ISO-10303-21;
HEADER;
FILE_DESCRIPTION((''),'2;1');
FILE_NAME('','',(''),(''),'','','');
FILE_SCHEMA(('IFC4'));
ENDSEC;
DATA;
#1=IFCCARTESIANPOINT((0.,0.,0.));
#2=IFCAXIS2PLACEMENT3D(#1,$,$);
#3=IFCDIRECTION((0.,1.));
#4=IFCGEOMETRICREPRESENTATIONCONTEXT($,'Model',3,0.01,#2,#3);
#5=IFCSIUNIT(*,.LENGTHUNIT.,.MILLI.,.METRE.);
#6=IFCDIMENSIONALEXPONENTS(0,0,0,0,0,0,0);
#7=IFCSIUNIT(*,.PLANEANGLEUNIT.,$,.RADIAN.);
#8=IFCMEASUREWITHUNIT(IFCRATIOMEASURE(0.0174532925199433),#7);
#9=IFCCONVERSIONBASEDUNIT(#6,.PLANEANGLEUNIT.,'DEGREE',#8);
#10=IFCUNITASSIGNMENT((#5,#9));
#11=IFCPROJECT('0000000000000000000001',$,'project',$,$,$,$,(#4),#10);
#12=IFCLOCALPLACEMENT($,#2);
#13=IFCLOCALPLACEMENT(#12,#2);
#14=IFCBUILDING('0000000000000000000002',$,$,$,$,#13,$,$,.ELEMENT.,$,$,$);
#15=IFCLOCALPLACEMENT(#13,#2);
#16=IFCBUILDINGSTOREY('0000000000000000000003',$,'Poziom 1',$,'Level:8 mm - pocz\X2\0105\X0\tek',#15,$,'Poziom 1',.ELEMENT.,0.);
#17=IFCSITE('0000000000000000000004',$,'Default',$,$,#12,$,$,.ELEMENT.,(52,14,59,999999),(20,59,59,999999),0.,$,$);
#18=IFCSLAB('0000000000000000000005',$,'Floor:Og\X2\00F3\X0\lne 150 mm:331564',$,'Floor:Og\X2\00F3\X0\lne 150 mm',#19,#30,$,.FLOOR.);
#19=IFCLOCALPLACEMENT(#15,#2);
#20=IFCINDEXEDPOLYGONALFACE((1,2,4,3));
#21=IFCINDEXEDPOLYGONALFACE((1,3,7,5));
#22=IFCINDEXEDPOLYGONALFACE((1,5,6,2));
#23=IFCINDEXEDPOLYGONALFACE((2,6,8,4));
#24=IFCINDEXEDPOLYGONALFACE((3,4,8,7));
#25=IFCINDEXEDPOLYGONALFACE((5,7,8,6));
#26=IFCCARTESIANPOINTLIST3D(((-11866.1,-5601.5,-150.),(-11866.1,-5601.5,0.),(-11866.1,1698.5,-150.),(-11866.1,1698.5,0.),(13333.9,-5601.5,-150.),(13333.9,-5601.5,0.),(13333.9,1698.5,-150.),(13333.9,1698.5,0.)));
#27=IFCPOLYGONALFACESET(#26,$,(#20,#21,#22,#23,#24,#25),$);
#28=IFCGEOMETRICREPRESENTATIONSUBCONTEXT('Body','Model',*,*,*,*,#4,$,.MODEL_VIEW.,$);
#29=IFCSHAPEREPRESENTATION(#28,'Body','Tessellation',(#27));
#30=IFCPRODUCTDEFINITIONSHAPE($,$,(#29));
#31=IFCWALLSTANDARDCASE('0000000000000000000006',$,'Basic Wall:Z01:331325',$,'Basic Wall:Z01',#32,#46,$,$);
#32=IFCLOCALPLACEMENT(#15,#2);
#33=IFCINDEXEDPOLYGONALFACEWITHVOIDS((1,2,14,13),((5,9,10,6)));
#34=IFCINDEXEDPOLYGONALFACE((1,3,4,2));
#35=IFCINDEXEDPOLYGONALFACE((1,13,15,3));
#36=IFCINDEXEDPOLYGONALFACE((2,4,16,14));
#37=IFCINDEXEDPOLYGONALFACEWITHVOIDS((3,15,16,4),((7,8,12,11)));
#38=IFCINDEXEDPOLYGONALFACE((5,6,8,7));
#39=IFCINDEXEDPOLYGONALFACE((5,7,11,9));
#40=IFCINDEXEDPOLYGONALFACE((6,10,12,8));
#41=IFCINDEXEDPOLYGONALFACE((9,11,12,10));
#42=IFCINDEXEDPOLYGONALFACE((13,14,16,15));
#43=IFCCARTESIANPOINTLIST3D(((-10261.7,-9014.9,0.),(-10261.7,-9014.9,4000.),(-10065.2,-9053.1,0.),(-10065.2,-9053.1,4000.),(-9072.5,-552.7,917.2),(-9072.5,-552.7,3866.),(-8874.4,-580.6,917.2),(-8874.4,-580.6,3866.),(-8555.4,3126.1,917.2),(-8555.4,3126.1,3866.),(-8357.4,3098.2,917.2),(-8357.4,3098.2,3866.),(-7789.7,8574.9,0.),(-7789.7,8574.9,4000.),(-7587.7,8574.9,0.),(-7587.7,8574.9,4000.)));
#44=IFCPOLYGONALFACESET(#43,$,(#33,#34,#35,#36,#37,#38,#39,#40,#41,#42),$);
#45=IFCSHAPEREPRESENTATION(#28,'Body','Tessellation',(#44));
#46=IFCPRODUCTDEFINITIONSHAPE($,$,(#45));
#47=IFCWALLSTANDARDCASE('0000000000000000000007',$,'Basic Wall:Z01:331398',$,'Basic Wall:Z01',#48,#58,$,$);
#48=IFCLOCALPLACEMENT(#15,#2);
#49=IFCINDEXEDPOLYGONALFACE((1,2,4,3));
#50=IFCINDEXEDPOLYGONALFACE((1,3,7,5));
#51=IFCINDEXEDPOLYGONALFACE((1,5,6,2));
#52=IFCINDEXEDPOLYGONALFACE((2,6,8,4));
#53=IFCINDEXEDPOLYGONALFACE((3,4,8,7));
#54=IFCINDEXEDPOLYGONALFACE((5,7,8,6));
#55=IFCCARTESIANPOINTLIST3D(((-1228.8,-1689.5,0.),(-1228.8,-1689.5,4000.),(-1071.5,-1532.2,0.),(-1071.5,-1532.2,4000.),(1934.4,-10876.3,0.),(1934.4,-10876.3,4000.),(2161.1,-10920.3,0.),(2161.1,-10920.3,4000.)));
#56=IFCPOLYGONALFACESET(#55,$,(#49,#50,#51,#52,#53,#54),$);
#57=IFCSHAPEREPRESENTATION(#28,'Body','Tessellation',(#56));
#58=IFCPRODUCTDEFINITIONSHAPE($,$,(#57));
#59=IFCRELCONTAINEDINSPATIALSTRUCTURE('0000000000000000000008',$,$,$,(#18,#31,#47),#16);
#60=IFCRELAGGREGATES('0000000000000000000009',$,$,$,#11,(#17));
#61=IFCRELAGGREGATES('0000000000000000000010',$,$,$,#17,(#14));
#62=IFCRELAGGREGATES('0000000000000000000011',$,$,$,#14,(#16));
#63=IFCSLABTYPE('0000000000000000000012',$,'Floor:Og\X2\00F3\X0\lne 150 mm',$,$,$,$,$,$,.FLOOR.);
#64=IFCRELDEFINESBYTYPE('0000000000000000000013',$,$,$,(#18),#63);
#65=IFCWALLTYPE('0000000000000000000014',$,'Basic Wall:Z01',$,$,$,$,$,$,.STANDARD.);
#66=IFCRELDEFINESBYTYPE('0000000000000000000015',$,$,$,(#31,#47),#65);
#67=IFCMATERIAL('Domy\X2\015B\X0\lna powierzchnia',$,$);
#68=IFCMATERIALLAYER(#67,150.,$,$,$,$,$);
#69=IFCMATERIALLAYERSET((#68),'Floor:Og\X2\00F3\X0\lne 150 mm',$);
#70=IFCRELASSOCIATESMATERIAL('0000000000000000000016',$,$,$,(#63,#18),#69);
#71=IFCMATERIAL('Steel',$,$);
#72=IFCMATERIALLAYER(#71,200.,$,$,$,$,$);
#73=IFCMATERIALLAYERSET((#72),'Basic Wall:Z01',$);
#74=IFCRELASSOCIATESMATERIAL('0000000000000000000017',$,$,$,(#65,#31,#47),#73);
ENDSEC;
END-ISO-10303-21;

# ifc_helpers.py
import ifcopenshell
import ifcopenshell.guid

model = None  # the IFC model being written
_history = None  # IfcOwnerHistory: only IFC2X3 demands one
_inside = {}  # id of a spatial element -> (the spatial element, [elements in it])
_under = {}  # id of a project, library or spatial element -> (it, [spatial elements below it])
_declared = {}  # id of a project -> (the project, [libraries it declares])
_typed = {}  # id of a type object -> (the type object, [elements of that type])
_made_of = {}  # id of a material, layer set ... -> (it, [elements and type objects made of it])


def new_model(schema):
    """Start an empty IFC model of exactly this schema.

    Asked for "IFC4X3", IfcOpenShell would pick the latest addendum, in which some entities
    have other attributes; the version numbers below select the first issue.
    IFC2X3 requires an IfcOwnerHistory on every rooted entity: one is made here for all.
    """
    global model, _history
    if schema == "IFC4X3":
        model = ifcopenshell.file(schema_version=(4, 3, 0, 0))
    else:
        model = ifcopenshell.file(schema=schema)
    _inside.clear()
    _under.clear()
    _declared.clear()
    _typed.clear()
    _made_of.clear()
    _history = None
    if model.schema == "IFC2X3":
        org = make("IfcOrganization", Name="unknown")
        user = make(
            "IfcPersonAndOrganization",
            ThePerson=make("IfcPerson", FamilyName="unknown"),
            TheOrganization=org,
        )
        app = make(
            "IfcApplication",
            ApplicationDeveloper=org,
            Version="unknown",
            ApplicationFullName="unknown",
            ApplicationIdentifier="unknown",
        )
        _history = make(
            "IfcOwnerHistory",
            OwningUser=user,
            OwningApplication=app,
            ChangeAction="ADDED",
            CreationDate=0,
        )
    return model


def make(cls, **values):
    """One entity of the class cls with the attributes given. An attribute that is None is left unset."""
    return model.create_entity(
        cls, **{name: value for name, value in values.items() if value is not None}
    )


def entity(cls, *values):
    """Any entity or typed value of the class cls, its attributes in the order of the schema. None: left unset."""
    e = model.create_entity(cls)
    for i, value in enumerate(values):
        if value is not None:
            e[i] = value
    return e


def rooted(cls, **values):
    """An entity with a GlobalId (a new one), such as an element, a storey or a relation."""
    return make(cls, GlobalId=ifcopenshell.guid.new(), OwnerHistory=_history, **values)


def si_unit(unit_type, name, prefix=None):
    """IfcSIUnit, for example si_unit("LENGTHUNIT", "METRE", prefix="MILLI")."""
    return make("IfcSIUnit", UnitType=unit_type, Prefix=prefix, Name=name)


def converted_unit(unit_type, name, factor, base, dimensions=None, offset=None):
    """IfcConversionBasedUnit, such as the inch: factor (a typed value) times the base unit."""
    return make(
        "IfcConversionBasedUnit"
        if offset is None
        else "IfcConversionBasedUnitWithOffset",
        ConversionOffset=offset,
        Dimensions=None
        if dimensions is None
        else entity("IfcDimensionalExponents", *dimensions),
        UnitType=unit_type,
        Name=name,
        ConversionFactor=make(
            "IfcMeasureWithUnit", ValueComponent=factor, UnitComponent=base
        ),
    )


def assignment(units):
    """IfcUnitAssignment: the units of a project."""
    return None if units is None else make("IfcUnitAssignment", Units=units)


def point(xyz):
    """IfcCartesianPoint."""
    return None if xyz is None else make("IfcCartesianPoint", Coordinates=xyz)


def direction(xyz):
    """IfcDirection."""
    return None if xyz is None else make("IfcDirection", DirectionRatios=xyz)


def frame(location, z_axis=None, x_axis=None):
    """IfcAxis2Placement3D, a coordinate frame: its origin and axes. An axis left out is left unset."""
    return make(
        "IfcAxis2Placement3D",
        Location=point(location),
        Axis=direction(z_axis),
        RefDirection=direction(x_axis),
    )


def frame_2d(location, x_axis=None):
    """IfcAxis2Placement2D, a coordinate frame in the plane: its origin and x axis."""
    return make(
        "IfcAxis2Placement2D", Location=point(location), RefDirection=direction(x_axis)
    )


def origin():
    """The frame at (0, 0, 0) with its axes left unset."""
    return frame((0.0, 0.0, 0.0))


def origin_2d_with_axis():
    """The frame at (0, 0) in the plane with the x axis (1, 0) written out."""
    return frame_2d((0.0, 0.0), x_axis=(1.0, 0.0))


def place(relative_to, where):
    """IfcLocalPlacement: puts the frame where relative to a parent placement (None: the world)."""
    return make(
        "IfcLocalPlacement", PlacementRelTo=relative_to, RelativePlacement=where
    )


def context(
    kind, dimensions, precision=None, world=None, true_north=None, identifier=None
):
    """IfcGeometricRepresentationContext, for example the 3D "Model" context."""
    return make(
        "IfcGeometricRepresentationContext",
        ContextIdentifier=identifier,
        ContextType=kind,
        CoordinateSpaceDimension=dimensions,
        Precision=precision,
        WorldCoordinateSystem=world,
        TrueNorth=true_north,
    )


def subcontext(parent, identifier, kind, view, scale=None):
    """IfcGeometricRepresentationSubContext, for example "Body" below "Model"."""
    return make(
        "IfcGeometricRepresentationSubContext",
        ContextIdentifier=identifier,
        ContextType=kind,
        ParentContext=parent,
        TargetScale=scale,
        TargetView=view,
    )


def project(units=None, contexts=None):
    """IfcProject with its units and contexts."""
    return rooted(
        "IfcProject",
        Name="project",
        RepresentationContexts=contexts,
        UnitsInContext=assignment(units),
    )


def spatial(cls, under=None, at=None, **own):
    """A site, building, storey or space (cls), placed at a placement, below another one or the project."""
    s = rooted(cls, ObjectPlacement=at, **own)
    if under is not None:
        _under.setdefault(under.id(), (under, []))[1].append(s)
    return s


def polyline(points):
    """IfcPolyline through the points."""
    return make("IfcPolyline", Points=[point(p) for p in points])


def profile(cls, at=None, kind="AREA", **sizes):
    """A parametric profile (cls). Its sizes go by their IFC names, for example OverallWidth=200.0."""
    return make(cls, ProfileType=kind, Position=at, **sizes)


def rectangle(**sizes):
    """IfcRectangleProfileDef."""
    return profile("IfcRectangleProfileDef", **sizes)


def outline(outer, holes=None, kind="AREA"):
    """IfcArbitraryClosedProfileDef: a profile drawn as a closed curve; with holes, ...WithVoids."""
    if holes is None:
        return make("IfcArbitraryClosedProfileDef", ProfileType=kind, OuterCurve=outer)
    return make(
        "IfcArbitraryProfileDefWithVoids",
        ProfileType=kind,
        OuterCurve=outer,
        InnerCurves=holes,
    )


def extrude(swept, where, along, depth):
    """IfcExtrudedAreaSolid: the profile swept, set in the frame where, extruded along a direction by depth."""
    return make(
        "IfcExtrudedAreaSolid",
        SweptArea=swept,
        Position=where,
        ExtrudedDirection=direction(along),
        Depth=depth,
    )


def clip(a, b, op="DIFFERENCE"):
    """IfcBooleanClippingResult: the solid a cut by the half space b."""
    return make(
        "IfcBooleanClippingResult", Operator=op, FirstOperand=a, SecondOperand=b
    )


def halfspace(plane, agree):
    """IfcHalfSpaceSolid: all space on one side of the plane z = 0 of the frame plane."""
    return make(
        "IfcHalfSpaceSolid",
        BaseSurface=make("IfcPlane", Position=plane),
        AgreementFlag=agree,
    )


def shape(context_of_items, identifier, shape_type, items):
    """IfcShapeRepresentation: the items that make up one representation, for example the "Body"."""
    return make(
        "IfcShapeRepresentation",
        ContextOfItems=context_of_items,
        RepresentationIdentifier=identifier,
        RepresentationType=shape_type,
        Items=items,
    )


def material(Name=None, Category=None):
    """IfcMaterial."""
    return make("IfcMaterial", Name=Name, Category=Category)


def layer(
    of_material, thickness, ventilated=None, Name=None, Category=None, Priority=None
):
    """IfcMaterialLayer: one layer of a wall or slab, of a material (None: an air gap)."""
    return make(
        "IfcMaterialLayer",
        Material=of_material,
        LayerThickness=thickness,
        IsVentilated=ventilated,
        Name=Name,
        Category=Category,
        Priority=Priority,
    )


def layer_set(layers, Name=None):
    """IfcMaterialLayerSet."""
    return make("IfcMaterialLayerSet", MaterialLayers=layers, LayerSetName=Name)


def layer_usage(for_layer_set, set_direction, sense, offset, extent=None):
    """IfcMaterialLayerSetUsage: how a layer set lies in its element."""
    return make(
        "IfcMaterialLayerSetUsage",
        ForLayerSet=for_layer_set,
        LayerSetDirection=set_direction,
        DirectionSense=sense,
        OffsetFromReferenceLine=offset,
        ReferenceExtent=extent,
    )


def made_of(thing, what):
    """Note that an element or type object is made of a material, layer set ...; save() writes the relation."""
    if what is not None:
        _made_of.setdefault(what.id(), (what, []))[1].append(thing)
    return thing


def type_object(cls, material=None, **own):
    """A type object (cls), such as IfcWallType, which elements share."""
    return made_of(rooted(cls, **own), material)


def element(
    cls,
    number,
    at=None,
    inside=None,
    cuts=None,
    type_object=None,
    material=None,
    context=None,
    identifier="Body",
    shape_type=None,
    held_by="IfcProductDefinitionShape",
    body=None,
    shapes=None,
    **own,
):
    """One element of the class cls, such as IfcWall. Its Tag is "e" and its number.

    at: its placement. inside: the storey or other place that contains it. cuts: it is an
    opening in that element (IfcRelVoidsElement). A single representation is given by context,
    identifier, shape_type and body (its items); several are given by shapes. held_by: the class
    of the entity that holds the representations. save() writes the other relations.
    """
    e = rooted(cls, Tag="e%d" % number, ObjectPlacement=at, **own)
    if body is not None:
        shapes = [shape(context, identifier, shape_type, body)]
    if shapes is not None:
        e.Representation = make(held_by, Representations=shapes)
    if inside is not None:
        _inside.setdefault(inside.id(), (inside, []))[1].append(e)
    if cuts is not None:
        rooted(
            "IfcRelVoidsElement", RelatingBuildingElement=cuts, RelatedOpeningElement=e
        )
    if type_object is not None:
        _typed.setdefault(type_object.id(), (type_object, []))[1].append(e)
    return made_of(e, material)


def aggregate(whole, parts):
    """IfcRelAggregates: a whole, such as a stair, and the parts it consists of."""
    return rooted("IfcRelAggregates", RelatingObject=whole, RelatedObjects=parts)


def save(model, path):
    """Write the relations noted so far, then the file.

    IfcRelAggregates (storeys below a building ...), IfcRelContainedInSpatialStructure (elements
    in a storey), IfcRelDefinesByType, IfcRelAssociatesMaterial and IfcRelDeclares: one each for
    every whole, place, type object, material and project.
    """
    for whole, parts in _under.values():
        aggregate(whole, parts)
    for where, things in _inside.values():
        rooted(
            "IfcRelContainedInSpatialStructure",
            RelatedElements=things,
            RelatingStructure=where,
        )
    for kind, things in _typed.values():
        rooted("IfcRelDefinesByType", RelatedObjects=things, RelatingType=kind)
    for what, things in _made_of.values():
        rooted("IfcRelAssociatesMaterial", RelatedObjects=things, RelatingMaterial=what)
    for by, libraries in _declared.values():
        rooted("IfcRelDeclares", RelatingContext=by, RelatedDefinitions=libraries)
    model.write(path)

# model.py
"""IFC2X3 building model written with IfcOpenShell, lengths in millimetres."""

from ifc_helpers import new_model, entity, si_unit, converted_unit, direction, frame, frame_2d, origin, origin_2d_with_axis, place, context, subcontext, project, spatial, polyline, rectangle, outline, extrude, clip, halfspace, material, layer, layer_set, layer_usage, type_object, element, save


model = new_model("IFC2X3")

# Units and contexts
model_context = context("Model", 3, precision=0.01, world=origin(), true_north=direction((0.0, 1.0)))
body_context = subcontext(model_context, "Body", "Model", "MODEL_VIEW")
ifc_project = project(units=[si_unit("LENGTHUNIT", "METRE", prefix="MILLI"), converted_unit("PLANEANGLEUNIT", "DEGREE", entity("IfcRatioMeasure", 0.0174532925199433), si_unit("PLANEANGLEUNIT", "RADIAN"), dimensions=[0, 0, 0, 0, 0, 0, 0])], contexts=[model_context])

# Site, building, storey
site_placement = place(None, origin())
site = spatial("IfcSite", under=ifc_project, at=site_placement, Name="Default", CompositionType="ELEMENT", RefLatitude=(52, 14, 59, 999999), RefLongitude=(20, 59, 59, 999999), RefElevation=0.0)
building_placement = place(site_placement, origin())
building = spatial("IfcBuilding", under=site, at=building_placement, CompositionType="ELEMENT")
storey_placement = place(building_placement, origin())
storey = spatial("IfcBuildingStorey", under=building, at=storey_placement, Name="Poziom 1", ObjectType="Level:8 mm - początek", LongName="Poziom 1", CompositionType="ELEMENT", Elevation=0.0)

# Slab
ifc_material_1 = material(Name="Domyślna powierzchnia")
ifc_layer_1 = layer(ifc_material_1, 150.0)
ifc_layer_set_1 = layer_set([ifc_layer_1], Name="Floor:Ogólne 150 mm")
ifc_layer_usage_1 = layer_usage(ifc_layer_set_1, "AXIS3", "POSITIVE", 0.0)
slab_type = type_object("IfcSlabType", Name="Floor:Ogólne 150 mm", PredefinedType="FLOOR", material=ifc_layer_set_1)
slab_placement = place(storey_placement, origin())
element("IfcSlab", 1, at=slab_placement, inside=storey, type_object=slab_type, material=ifc_layer_usage_1, Name="Floor:Ogólne 150 mm:331564", ObjectType="Floor:Ogólne 150 mm", PredefinedType="FLOOR", context=body_context, shape_type="SweptSolid", body=[
    extrude(rectangle(XDim=7300.0, YDim=25200.0, at=frame_2d((0.0, 0.0), x_axis=(1.0, 0.0))), frame((733.9, -1951.5, 0.0), z_axis=(0.0, 0.0, -1.0), x_axis=(0.0, 1.0, 0.0)), (0.0, 0.0, 1.0), 150.0),
])

# Wall, opening
ifc_material_2 = material(Name="Steel")
ifc_layer_2 = layer(ifc_material_2, 200.0)
ifc_layer_set_2 = layer_set([ifc_layer_2], Name="Basic Wall:Z01")
ifc_layer_usage_2 = layer_usage(ifc_layer_set_2, "AXIS2", "NEGATIVE", 100.0)
wall_type_1 = type_object("IfcWallType", Name="Basic Wall:Z01", PredefinedType="STANDARD", material=ifc_layer_set_2)
wall_1_placement = place(storey_placement, frame((-7686.7, 8588.8, 0.0), z_axis=(0.0, 0.0, 1.0), x_axis=(-0.139173, -0.990268, 0.0)))
wall_1 = element("IfcWallStandardCase", 2, at=wall_1_placement, inside=storey, type_object=wall_type_1, material=ifc_layer_usage_2, Name="Basic Wall:Z01:331325", ObjectType="Basic Wall:Z01", context=body_context, shape_type="Clipping", body=[
    clip(extrude(outline(polyline([(17790.8, -100.0), (17801.2, 100.0), (17300.6, 100.0), (504.9, 100.0), (0.0, 100.0), (28.1, -100.0), (17790.8, -100.0)])), origin(), (0.0, 0.0, 1.0), 4000.0), halfspace(origin(), True)),
])
opening_1_placement = place(wall_1_placement, origin())
element("IfcOpeningElement", 3, at=opening_1_placement, cuts=wall_1, ObjectType="Opening", context=body_context, shape_type="SweptSolid", body=[
    extrude(rectangle(XDim=2948.8, YDim=3715.0, at=origin_2d_with_axis()), frame((7387.9, -100.0, 2391.6), z_axis=(0.0, 1.0, 0.0), x_axis=(0.0, 0.0, -1.0)), (0.0, 0.0, 1.0), 200.0),
])

# Wall
ifc_layer_usage_3 = layer_usage(ifc_layer_set_2, "AXIS2", "NEGATIVE", 100.0)
wall_2_placement = place(storey_placement, frame((2066.5, -10952.9, 0.0), z_axis=(0.0, 0.0, 1.0), x_axis=(-0.325568, 0.945519, 0.0)))
element("IfcWallStandardCase", 4, at=wall_2_placement, inside=storey, type_object=wall_type_1, material=ifc_layer_usage_3, Name="Basic Wall:Z01:331398", ObjectType="Basic Wall:Z01", context=body_context, shape_type="Clipping", body=[
    clip(extrude(outline(polyline([(9929.1, -100.0), (9831.5, 100.0), (115.5, 100.0), (0.0, -100.0), (9706.6, -100.0), (9929.1, -100.0)])), origin(), (0.0, 0.0, 1.0), 4000.0), halfspace(origin(), True)),
])

save(model, "model.ifc")
